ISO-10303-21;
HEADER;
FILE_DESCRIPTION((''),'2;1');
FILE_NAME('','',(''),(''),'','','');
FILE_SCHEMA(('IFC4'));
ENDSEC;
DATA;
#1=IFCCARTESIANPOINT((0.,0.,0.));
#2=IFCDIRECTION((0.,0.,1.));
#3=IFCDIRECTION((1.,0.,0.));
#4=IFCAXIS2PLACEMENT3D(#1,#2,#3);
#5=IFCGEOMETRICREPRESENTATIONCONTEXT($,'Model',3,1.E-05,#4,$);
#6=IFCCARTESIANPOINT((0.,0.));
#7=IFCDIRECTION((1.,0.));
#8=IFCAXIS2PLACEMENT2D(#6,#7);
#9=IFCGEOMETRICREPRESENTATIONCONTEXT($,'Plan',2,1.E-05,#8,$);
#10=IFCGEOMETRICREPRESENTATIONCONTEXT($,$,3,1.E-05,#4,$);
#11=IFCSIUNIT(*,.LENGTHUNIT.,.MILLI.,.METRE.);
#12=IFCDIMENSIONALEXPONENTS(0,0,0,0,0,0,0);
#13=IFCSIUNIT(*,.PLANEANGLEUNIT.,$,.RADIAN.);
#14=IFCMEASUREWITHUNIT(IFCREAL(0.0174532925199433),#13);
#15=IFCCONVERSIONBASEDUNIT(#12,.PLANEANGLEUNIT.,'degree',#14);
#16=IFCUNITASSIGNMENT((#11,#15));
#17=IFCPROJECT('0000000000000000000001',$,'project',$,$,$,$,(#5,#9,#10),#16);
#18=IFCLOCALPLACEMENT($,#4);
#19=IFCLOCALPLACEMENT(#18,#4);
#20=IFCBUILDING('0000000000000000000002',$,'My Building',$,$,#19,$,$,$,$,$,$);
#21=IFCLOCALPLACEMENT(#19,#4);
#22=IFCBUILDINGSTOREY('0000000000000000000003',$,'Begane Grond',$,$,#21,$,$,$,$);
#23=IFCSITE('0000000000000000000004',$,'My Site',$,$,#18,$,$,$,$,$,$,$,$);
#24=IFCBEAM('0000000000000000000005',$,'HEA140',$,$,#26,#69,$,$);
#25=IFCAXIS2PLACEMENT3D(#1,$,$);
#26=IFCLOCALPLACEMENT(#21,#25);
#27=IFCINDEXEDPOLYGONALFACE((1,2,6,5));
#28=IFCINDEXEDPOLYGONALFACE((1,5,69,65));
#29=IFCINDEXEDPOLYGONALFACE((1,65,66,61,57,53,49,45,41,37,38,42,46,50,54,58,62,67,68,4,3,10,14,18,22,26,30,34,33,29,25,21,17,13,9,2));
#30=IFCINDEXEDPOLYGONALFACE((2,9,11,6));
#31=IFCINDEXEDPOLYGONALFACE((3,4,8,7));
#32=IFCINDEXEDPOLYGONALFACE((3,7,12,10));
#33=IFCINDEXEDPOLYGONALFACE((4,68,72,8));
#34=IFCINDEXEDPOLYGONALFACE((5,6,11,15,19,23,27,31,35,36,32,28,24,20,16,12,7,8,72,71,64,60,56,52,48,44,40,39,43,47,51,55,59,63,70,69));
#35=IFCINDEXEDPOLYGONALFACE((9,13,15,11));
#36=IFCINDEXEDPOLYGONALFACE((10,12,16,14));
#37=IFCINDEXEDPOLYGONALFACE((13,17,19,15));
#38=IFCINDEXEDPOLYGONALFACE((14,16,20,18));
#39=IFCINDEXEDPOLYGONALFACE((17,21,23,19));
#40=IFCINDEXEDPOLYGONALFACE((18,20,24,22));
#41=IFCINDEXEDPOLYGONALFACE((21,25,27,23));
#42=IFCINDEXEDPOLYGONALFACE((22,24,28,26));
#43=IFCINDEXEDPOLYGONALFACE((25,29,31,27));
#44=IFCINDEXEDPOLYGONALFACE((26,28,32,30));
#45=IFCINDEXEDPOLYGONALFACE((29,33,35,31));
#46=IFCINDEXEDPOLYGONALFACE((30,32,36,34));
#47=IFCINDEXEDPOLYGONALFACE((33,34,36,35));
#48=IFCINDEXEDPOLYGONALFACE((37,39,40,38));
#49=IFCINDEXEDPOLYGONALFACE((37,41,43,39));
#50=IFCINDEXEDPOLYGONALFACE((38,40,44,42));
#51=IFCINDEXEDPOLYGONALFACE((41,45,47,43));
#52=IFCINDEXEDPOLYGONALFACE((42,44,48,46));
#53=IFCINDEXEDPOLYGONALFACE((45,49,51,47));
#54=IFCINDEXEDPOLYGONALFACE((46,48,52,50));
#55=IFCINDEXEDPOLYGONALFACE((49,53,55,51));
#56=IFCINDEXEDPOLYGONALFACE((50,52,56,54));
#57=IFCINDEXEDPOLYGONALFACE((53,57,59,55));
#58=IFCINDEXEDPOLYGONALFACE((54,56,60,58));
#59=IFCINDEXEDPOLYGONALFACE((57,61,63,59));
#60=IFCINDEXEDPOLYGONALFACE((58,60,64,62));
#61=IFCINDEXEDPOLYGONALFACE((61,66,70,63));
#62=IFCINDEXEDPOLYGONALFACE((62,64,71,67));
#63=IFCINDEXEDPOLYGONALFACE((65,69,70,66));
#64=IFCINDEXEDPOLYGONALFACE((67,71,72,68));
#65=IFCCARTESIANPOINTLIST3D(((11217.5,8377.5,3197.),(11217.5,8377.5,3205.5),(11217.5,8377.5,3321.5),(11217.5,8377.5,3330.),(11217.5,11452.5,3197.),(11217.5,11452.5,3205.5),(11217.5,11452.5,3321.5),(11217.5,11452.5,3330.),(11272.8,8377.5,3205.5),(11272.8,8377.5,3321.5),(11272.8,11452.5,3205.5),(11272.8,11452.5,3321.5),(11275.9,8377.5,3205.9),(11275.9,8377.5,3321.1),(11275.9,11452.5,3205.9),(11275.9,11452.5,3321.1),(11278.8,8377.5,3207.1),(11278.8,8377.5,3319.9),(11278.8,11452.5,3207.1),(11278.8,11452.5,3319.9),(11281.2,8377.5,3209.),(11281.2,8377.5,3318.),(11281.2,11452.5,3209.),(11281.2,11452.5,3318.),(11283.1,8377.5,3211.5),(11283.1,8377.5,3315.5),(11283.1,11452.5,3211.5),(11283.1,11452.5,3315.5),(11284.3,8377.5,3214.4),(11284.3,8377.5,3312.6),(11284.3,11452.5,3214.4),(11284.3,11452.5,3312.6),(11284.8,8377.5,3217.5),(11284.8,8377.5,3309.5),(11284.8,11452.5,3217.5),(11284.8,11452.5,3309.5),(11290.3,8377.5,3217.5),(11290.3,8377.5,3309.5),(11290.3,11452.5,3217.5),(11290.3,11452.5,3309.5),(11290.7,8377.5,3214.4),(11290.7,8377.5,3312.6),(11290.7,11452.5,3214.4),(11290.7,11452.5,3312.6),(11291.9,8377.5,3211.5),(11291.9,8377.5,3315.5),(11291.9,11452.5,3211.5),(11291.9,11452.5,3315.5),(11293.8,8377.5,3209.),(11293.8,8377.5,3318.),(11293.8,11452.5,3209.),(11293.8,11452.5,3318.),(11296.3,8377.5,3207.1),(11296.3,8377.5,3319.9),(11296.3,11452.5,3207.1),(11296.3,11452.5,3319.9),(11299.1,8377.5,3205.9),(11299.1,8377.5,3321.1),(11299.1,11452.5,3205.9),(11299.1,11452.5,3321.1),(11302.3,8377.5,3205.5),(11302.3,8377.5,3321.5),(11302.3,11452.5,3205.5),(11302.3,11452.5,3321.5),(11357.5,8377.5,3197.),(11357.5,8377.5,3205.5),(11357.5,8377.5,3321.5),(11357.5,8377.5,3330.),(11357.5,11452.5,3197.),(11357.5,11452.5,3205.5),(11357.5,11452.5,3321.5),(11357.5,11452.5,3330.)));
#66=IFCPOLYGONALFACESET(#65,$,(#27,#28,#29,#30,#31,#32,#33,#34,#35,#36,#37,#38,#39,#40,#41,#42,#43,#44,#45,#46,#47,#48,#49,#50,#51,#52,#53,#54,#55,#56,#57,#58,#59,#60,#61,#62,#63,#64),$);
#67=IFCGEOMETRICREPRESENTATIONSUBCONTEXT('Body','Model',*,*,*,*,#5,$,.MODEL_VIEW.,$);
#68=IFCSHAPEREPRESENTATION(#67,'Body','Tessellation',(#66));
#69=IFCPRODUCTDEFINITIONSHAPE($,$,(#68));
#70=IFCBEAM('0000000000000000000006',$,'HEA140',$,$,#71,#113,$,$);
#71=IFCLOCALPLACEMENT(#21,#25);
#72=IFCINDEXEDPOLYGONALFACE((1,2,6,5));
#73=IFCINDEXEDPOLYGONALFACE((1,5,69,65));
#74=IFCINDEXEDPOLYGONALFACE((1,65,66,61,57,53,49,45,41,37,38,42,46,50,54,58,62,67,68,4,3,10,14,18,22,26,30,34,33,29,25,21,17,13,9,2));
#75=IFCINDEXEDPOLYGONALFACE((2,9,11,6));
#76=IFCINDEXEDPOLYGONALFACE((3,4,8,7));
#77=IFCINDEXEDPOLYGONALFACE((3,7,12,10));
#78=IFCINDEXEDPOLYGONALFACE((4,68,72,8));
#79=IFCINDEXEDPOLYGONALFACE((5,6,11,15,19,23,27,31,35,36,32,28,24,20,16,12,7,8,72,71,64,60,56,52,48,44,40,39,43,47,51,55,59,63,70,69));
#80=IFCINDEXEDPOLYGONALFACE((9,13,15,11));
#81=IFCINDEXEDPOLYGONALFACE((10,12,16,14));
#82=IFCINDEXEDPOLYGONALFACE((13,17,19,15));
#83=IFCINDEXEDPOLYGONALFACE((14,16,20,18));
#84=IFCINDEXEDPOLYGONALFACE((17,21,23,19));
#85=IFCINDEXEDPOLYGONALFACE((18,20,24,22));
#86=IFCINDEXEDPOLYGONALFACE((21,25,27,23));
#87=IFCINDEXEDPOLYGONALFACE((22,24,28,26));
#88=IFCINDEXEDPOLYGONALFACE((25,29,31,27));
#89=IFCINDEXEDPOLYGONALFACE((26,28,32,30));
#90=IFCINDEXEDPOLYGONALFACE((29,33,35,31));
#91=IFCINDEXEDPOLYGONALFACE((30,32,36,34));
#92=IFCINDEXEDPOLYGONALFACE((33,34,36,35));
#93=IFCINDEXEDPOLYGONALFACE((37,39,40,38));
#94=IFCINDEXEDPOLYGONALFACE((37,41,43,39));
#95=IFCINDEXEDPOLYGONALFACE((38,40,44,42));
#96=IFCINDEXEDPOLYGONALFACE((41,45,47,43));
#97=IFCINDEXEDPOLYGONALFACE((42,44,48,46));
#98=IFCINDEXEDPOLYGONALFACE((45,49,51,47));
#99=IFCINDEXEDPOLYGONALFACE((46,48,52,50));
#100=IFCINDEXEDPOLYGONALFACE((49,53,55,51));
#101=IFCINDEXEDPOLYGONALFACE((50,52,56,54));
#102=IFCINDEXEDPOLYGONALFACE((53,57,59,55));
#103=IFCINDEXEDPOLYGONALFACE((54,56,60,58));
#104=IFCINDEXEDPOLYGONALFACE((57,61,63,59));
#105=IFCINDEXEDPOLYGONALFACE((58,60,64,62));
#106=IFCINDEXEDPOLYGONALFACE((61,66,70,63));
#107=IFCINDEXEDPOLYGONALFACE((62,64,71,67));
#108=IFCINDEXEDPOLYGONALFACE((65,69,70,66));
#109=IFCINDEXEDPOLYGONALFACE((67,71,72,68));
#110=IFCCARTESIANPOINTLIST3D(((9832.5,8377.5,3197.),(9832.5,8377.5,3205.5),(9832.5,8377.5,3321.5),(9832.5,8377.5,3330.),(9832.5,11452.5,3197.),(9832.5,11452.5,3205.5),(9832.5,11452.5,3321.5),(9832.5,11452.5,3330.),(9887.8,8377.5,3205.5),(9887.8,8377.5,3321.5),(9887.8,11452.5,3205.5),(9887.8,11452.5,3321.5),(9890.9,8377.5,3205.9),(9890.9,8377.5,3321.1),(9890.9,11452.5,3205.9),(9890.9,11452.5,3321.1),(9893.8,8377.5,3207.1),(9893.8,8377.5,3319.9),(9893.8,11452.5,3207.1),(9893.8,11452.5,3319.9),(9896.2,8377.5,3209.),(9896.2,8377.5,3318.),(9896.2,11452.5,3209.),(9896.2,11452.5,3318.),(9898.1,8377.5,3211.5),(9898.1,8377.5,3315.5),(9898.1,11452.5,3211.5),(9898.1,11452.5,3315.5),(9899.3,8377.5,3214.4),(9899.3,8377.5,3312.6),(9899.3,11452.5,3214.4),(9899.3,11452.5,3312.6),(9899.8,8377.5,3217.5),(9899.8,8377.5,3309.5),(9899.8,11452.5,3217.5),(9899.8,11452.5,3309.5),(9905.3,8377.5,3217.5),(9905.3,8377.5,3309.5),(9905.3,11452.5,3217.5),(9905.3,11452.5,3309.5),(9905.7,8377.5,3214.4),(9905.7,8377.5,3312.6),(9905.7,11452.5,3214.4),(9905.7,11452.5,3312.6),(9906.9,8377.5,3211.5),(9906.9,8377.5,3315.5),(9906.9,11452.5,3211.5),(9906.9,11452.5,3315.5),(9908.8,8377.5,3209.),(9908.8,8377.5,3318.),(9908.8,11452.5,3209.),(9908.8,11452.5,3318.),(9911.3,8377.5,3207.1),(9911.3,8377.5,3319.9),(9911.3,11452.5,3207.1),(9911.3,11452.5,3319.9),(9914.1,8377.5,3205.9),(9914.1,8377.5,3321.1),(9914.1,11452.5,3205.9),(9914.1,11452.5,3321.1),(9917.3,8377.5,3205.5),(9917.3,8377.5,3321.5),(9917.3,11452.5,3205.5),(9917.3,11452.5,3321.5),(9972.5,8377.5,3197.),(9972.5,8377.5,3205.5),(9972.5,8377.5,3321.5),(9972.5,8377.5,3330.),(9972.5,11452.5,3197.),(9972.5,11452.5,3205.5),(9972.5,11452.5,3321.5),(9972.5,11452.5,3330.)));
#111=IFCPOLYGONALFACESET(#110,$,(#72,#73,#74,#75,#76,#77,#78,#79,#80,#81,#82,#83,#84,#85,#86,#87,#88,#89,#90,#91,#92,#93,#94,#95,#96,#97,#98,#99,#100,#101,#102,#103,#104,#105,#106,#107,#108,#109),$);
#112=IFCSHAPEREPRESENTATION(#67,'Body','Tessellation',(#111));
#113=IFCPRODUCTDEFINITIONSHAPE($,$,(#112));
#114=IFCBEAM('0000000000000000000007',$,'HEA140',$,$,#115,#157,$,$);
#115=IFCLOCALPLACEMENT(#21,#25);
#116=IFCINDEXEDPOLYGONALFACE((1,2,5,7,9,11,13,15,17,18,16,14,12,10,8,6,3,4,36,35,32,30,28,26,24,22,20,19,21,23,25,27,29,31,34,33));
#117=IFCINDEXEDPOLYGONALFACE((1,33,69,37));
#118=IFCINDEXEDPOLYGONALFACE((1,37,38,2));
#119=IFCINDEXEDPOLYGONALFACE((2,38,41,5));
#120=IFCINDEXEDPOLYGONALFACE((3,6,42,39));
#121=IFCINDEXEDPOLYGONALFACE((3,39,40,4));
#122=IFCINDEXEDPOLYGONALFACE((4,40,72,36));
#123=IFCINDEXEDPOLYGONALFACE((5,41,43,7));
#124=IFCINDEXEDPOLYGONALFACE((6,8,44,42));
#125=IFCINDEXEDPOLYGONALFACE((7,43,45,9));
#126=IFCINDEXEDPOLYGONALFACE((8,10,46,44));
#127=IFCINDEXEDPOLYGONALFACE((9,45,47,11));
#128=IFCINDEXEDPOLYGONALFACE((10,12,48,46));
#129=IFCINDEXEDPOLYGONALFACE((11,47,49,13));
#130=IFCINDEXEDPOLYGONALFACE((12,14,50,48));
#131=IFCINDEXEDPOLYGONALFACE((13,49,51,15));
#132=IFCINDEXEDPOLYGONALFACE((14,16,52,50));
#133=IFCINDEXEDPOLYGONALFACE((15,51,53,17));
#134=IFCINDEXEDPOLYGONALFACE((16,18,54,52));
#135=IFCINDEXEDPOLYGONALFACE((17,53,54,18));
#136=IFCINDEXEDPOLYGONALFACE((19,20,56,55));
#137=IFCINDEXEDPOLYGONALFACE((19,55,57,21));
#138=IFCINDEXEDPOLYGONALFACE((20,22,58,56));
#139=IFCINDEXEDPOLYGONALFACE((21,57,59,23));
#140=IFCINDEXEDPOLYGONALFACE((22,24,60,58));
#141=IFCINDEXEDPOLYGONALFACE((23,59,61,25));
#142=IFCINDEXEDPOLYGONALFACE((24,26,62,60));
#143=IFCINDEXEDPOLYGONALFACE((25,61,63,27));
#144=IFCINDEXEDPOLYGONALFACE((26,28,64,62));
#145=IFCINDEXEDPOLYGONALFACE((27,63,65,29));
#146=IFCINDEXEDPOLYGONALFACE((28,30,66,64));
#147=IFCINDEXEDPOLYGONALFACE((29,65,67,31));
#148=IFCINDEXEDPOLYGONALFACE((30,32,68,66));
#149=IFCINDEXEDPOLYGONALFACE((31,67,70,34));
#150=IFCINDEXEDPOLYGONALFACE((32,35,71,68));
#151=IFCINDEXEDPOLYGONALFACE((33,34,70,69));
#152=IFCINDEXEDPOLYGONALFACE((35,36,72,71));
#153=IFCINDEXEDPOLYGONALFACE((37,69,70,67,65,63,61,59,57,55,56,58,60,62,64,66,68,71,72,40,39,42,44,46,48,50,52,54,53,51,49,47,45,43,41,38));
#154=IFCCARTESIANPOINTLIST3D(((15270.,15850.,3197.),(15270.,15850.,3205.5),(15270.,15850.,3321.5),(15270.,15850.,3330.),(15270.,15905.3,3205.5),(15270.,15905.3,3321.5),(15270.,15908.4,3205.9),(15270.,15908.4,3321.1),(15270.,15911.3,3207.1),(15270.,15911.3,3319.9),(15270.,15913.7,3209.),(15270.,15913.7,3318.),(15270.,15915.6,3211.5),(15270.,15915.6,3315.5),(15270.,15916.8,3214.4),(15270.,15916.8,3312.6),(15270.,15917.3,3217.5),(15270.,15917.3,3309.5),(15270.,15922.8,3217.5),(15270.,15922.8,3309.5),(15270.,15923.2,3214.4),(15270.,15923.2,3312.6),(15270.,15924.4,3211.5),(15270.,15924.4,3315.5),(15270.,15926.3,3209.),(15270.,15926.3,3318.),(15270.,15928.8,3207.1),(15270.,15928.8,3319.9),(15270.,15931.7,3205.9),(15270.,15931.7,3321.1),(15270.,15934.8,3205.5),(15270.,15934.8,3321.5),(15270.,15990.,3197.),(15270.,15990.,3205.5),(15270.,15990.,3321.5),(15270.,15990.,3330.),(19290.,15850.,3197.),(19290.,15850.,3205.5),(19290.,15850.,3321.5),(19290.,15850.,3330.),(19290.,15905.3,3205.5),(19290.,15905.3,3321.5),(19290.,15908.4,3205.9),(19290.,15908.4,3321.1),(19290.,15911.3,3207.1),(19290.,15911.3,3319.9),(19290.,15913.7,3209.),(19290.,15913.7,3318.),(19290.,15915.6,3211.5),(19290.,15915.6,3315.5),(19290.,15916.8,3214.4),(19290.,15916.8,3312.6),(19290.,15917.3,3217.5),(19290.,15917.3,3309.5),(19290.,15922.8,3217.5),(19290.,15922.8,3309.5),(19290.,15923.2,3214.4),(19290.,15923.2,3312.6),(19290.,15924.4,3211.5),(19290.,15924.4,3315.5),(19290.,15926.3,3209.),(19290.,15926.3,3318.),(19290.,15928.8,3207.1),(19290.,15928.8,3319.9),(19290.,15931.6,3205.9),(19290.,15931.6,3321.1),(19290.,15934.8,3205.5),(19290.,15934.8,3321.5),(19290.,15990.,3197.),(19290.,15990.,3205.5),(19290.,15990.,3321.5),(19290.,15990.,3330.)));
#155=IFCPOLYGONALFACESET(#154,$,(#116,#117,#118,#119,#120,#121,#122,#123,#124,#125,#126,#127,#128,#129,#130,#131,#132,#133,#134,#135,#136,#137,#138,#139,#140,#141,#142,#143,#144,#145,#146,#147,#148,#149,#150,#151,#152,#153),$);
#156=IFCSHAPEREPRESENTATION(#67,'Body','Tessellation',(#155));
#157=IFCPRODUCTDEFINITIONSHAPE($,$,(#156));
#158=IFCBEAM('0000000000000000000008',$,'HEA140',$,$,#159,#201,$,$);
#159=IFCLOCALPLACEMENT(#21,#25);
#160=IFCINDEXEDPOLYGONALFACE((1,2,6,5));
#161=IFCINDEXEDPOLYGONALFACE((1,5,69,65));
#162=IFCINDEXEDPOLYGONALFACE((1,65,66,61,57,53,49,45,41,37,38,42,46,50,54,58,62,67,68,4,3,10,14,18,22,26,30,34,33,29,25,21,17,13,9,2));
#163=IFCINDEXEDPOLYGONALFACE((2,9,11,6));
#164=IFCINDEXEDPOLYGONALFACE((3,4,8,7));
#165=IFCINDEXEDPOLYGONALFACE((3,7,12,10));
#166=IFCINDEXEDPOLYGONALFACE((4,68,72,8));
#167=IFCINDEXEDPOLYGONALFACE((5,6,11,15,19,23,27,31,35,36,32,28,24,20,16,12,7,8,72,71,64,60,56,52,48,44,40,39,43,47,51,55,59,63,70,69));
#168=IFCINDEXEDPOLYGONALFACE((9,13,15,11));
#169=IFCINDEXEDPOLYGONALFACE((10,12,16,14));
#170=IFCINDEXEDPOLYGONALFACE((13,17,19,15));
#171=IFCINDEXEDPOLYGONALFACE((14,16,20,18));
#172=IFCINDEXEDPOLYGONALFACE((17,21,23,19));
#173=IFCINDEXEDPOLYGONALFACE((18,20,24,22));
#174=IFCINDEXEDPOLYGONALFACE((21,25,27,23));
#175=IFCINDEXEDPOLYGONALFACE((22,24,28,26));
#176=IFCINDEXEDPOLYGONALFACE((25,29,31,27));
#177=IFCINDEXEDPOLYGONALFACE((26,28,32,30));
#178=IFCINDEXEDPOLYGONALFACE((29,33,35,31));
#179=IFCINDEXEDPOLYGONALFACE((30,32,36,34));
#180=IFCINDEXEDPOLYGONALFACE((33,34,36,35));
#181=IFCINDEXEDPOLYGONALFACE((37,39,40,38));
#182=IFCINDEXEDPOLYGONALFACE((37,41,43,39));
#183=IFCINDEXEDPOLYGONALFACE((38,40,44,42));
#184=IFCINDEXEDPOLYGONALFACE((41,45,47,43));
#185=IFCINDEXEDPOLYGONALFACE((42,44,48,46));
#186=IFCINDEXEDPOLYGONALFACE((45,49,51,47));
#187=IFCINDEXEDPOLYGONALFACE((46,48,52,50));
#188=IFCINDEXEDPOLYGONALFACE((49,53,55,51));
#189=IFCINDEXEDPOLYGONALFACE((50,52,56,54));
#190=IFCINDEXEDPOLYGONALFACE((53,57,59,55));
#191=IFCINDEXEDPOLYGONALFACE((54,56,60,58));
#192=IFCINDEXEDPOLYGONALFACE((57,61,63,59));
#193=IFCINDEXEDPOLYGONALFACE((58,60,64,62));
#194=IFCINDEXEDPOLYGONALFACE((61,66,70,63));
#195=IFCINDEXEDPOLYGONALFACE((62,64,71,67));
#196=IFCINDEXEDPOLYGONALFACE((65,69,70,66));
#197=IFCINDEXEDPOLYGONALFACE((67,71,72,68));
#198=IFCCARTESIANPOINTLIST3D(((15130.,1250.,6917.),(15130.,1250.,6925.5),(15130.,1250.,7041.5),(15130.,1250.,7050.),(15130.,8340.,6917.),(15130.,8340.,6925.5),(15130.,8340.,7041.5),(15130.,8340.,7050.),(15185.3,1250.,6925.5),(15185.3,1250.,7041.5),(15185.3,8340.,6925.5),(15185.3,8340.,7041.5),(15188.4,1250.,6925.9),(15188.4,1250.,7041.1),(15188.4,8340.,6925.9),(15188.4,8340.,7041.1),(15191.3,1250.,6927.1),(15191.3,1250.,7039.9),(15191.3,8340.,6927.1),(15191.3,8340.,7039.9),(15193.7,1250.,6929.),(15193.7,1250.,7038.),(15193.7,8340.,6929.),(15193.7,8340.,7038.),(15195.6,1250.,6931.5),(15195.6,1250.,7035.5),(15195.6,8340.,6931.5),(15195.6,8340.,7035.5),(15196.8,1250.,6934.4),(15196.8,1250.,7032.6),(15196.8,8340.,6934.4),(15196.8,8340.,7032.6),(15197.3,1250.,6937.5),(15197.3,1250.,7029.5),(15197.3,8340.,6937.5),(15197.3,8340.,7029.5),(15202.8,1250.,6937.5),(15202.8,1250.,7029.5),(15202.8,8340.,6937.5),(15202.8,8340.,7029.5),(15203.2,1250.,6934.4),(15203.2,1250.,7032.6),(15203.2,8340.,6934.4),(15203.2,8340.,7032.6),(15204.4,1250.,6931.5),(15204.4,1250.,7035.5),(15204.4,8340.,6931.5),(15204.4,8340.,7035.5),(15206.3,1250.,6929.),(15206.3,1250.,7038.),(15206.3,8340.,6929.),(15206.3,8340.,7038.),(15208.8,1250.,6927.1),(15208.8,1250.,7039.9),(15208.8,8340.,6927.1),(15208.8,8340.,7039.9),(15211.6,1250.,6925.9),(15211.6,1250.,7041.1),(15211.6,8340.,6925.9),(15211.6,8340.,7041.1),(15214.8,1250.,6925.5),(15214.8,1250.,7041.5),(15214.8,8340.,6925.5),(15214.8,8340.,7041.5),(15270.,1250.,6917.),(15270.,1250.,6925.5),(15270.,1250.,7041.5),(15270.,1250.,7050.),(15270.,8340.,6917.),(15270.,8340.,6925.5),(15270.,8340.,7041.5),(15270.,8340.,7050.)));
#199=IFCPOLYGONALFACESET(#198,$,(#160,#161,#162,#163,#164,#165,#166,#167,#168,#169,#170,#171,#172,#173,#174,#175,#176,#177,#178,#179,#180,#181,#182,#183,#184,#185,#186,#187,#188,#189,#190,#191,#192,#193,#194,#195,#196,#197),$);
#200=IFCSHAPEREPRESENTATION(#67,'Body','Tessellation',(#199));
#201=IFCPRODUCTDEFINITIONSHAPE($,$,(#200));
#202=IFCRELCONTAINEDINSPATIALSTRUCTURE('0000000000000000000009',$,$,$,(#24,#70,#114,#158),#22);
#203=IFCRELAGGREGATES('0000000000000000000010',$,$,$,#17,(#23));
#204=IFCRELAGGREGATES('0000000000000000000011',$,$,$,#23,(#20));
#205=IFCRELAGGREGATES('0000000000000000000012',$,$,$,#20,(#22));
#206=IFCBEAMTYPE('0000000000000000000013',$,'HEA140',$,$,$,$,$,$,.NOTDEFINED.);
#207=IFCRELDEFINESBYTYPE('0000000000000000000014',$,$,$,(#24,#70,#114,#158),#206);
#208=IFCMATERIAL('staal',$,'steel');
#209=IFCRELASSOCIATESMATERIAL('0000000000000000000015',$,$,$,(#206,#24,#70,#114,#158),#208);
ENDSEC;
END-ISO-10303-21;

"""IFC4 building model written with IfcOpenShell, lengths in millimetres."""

from ifc_helpers import new_model, entity, si_unit, converted_unit, frame, origin_with_axes, origin_2d_with_axis, place, context, subcontext, project, spatial, i_section, extrude, material, material_profile, profile_set, profile_usage, type_object, element, save


model = new_model("IFC4")

# Units and contexts
model_context = context("Model", 3, precision=1e-05, world=origin_with_axes())
plan_context = context("Plan", 2, precision=1e-05, world=origin_2d_with_axis())
context_of_model = context(None, 3, precision=1e-05, world=origin_with_axes())
body_context = subcontext(model_context, "Body", "Model", "MODEL_VIEW")
ifc_project = project(units=[si_unit("LENGTHUNIT", "METRE", prefix="MILLI"), converted_unit("PLANEANGLEUNIT", "degree", entity("IfcReal", 0.0174532925199433), si_unit("PLANEANGLEUNIT", "RADIAN"), dimensions=[0, 0, 0, 0, 0, 0, 0])], contexts=[model_context, plan_context, context_of_model])

# Site, building, storey
site_placement = place(None, origin_with_axes())
site = spatial("IfcSite", under=ifc_project, at=site_placement, Name="My Site")
building_placement = place(site_placement, origin_with_axes())
building = spatial("IfcBuilding", under=site, at=building_placement, Name="My Building")
storey_placement = place(building_placement, origin_with_axes())
storey = spatial("IfcBuildingStorey", under=building, at=storey_placement, Name="Begane Grond")

# Shared definitions
ifc_material = material(Name="staal", Category="steel")

# Beams
ifc_material_profile_1 = material_profile(ifc_material, i_section(OverallWidth=140.0, OverallDepth=133.0, WebThickness=5.5, FlangeThickness=8.5, FilletRadius=12.0))
ifc_profile_set_1 = profile_set([ifc_material_profile_1], Name="HEA140")
ifc_profile_usage_1 = profile_usage(ifc_profile_set_1)
beam_type_1 = type_object("IfcBeamType", Name="HEA140", PredefinedType="NOTDEFINED", material=ifc_profile_set_1)
beam_1_placement = place(storey_placement, frame((11287.5, 8377.5, 3263.5), z_axis=(0.0, 1.0, 0.0), x_axis=(-1.0, 0.0, 0.0)))
element("IfcBeam", 1, at=beam_1_placement, inside=storey, type_object=beam_type_1, material=ifc_profile_usage_1, Name="HEA140", context=body_context, shape_type="SweptSolid", body=[
    extrude(i_section(OverallWidth=140.0, OverallDepth=133.0, WebThickness=5.5, FlangeThickness=8.5, FilletRadius=12.0), origin_with_axes(), (0.0, 0.0, 1.0), 3075.0),
])
ifc_profile_usage_2 = profile_usage(ifc_profile_set_1)
beam_2_placement = place(storey_placement, frame((9902.5, 8377.5, 3263.5), z_axis=(0.0, 1.0, 0.0), x_axis=(-1.0, 0.0, 0.0)))
element("IfcBeam", 2, at=beam_2_placement, inside=storey, type_object=beam_type_1, material=ifc_profile_usage_2, Name="HEA140", context=body_context, shape_type="SweptSolid", body=[
    extrude(i_section(OverallWidth=140.0, OverallDepth=133.0, WebThickness=5.5, FlangeThickness=8.5, FilletRadius=12.0), origin_with_axes(), (0.0, 0.0, 1.0), 3075.0),
])
ifc_profile_usage_3 = profile_usage(ifc_profile_set_1)
beam_3_placement = place(storey_placement, frame((19290.0, 15920.0, 3263.5), z_axis=(-1.0, 0.0, 0.0), x_axis=(0.0, -1.0, 0.0)))
element("IfcBeam", 3, at=beam_3_placement, inside=storey, type_object=beam_type_1, material=ifc_profile_usage_3, Name="HEA140", context=body_context, shape_type="SweptSolid", body=[
    extrude(i_section(OverallWidth=140.0, OverallDepth=133.0, WebThickness=5.5, FlangeThickness=8.5, FilletRadius=12.0), origin_with_axes(), (0.0, 0.0, 1.0), 4020.0),
])
ifc_profile_usage_4 = profile_usage(ifc_profile_set_1)
beam_4_placement = place(storey_placement, frame((15200.0, 1250.0, 6983.5), z_axis=(0.0, 1.0, 0.0), x_axis=(-1.0, 0.0, 0.0)))
element("IfcBeam", 4, at=beam_4_placement, inside=storey, type_object=beam_type_1, material=ifc_profile_usage_4, Name="HEA140", context=body_context, shape_type="SweptSolid", body=[
    extrude(i_section(OverallWidth=140.0, OverallDepth=133.0, WebThickness=5.5, FlangeThickness=8.5, FilletRadius=12.0), origin_with_axes(), (0.0, 0.0, 1.0), 7090.0),
])

save(model, "model.ifc")
